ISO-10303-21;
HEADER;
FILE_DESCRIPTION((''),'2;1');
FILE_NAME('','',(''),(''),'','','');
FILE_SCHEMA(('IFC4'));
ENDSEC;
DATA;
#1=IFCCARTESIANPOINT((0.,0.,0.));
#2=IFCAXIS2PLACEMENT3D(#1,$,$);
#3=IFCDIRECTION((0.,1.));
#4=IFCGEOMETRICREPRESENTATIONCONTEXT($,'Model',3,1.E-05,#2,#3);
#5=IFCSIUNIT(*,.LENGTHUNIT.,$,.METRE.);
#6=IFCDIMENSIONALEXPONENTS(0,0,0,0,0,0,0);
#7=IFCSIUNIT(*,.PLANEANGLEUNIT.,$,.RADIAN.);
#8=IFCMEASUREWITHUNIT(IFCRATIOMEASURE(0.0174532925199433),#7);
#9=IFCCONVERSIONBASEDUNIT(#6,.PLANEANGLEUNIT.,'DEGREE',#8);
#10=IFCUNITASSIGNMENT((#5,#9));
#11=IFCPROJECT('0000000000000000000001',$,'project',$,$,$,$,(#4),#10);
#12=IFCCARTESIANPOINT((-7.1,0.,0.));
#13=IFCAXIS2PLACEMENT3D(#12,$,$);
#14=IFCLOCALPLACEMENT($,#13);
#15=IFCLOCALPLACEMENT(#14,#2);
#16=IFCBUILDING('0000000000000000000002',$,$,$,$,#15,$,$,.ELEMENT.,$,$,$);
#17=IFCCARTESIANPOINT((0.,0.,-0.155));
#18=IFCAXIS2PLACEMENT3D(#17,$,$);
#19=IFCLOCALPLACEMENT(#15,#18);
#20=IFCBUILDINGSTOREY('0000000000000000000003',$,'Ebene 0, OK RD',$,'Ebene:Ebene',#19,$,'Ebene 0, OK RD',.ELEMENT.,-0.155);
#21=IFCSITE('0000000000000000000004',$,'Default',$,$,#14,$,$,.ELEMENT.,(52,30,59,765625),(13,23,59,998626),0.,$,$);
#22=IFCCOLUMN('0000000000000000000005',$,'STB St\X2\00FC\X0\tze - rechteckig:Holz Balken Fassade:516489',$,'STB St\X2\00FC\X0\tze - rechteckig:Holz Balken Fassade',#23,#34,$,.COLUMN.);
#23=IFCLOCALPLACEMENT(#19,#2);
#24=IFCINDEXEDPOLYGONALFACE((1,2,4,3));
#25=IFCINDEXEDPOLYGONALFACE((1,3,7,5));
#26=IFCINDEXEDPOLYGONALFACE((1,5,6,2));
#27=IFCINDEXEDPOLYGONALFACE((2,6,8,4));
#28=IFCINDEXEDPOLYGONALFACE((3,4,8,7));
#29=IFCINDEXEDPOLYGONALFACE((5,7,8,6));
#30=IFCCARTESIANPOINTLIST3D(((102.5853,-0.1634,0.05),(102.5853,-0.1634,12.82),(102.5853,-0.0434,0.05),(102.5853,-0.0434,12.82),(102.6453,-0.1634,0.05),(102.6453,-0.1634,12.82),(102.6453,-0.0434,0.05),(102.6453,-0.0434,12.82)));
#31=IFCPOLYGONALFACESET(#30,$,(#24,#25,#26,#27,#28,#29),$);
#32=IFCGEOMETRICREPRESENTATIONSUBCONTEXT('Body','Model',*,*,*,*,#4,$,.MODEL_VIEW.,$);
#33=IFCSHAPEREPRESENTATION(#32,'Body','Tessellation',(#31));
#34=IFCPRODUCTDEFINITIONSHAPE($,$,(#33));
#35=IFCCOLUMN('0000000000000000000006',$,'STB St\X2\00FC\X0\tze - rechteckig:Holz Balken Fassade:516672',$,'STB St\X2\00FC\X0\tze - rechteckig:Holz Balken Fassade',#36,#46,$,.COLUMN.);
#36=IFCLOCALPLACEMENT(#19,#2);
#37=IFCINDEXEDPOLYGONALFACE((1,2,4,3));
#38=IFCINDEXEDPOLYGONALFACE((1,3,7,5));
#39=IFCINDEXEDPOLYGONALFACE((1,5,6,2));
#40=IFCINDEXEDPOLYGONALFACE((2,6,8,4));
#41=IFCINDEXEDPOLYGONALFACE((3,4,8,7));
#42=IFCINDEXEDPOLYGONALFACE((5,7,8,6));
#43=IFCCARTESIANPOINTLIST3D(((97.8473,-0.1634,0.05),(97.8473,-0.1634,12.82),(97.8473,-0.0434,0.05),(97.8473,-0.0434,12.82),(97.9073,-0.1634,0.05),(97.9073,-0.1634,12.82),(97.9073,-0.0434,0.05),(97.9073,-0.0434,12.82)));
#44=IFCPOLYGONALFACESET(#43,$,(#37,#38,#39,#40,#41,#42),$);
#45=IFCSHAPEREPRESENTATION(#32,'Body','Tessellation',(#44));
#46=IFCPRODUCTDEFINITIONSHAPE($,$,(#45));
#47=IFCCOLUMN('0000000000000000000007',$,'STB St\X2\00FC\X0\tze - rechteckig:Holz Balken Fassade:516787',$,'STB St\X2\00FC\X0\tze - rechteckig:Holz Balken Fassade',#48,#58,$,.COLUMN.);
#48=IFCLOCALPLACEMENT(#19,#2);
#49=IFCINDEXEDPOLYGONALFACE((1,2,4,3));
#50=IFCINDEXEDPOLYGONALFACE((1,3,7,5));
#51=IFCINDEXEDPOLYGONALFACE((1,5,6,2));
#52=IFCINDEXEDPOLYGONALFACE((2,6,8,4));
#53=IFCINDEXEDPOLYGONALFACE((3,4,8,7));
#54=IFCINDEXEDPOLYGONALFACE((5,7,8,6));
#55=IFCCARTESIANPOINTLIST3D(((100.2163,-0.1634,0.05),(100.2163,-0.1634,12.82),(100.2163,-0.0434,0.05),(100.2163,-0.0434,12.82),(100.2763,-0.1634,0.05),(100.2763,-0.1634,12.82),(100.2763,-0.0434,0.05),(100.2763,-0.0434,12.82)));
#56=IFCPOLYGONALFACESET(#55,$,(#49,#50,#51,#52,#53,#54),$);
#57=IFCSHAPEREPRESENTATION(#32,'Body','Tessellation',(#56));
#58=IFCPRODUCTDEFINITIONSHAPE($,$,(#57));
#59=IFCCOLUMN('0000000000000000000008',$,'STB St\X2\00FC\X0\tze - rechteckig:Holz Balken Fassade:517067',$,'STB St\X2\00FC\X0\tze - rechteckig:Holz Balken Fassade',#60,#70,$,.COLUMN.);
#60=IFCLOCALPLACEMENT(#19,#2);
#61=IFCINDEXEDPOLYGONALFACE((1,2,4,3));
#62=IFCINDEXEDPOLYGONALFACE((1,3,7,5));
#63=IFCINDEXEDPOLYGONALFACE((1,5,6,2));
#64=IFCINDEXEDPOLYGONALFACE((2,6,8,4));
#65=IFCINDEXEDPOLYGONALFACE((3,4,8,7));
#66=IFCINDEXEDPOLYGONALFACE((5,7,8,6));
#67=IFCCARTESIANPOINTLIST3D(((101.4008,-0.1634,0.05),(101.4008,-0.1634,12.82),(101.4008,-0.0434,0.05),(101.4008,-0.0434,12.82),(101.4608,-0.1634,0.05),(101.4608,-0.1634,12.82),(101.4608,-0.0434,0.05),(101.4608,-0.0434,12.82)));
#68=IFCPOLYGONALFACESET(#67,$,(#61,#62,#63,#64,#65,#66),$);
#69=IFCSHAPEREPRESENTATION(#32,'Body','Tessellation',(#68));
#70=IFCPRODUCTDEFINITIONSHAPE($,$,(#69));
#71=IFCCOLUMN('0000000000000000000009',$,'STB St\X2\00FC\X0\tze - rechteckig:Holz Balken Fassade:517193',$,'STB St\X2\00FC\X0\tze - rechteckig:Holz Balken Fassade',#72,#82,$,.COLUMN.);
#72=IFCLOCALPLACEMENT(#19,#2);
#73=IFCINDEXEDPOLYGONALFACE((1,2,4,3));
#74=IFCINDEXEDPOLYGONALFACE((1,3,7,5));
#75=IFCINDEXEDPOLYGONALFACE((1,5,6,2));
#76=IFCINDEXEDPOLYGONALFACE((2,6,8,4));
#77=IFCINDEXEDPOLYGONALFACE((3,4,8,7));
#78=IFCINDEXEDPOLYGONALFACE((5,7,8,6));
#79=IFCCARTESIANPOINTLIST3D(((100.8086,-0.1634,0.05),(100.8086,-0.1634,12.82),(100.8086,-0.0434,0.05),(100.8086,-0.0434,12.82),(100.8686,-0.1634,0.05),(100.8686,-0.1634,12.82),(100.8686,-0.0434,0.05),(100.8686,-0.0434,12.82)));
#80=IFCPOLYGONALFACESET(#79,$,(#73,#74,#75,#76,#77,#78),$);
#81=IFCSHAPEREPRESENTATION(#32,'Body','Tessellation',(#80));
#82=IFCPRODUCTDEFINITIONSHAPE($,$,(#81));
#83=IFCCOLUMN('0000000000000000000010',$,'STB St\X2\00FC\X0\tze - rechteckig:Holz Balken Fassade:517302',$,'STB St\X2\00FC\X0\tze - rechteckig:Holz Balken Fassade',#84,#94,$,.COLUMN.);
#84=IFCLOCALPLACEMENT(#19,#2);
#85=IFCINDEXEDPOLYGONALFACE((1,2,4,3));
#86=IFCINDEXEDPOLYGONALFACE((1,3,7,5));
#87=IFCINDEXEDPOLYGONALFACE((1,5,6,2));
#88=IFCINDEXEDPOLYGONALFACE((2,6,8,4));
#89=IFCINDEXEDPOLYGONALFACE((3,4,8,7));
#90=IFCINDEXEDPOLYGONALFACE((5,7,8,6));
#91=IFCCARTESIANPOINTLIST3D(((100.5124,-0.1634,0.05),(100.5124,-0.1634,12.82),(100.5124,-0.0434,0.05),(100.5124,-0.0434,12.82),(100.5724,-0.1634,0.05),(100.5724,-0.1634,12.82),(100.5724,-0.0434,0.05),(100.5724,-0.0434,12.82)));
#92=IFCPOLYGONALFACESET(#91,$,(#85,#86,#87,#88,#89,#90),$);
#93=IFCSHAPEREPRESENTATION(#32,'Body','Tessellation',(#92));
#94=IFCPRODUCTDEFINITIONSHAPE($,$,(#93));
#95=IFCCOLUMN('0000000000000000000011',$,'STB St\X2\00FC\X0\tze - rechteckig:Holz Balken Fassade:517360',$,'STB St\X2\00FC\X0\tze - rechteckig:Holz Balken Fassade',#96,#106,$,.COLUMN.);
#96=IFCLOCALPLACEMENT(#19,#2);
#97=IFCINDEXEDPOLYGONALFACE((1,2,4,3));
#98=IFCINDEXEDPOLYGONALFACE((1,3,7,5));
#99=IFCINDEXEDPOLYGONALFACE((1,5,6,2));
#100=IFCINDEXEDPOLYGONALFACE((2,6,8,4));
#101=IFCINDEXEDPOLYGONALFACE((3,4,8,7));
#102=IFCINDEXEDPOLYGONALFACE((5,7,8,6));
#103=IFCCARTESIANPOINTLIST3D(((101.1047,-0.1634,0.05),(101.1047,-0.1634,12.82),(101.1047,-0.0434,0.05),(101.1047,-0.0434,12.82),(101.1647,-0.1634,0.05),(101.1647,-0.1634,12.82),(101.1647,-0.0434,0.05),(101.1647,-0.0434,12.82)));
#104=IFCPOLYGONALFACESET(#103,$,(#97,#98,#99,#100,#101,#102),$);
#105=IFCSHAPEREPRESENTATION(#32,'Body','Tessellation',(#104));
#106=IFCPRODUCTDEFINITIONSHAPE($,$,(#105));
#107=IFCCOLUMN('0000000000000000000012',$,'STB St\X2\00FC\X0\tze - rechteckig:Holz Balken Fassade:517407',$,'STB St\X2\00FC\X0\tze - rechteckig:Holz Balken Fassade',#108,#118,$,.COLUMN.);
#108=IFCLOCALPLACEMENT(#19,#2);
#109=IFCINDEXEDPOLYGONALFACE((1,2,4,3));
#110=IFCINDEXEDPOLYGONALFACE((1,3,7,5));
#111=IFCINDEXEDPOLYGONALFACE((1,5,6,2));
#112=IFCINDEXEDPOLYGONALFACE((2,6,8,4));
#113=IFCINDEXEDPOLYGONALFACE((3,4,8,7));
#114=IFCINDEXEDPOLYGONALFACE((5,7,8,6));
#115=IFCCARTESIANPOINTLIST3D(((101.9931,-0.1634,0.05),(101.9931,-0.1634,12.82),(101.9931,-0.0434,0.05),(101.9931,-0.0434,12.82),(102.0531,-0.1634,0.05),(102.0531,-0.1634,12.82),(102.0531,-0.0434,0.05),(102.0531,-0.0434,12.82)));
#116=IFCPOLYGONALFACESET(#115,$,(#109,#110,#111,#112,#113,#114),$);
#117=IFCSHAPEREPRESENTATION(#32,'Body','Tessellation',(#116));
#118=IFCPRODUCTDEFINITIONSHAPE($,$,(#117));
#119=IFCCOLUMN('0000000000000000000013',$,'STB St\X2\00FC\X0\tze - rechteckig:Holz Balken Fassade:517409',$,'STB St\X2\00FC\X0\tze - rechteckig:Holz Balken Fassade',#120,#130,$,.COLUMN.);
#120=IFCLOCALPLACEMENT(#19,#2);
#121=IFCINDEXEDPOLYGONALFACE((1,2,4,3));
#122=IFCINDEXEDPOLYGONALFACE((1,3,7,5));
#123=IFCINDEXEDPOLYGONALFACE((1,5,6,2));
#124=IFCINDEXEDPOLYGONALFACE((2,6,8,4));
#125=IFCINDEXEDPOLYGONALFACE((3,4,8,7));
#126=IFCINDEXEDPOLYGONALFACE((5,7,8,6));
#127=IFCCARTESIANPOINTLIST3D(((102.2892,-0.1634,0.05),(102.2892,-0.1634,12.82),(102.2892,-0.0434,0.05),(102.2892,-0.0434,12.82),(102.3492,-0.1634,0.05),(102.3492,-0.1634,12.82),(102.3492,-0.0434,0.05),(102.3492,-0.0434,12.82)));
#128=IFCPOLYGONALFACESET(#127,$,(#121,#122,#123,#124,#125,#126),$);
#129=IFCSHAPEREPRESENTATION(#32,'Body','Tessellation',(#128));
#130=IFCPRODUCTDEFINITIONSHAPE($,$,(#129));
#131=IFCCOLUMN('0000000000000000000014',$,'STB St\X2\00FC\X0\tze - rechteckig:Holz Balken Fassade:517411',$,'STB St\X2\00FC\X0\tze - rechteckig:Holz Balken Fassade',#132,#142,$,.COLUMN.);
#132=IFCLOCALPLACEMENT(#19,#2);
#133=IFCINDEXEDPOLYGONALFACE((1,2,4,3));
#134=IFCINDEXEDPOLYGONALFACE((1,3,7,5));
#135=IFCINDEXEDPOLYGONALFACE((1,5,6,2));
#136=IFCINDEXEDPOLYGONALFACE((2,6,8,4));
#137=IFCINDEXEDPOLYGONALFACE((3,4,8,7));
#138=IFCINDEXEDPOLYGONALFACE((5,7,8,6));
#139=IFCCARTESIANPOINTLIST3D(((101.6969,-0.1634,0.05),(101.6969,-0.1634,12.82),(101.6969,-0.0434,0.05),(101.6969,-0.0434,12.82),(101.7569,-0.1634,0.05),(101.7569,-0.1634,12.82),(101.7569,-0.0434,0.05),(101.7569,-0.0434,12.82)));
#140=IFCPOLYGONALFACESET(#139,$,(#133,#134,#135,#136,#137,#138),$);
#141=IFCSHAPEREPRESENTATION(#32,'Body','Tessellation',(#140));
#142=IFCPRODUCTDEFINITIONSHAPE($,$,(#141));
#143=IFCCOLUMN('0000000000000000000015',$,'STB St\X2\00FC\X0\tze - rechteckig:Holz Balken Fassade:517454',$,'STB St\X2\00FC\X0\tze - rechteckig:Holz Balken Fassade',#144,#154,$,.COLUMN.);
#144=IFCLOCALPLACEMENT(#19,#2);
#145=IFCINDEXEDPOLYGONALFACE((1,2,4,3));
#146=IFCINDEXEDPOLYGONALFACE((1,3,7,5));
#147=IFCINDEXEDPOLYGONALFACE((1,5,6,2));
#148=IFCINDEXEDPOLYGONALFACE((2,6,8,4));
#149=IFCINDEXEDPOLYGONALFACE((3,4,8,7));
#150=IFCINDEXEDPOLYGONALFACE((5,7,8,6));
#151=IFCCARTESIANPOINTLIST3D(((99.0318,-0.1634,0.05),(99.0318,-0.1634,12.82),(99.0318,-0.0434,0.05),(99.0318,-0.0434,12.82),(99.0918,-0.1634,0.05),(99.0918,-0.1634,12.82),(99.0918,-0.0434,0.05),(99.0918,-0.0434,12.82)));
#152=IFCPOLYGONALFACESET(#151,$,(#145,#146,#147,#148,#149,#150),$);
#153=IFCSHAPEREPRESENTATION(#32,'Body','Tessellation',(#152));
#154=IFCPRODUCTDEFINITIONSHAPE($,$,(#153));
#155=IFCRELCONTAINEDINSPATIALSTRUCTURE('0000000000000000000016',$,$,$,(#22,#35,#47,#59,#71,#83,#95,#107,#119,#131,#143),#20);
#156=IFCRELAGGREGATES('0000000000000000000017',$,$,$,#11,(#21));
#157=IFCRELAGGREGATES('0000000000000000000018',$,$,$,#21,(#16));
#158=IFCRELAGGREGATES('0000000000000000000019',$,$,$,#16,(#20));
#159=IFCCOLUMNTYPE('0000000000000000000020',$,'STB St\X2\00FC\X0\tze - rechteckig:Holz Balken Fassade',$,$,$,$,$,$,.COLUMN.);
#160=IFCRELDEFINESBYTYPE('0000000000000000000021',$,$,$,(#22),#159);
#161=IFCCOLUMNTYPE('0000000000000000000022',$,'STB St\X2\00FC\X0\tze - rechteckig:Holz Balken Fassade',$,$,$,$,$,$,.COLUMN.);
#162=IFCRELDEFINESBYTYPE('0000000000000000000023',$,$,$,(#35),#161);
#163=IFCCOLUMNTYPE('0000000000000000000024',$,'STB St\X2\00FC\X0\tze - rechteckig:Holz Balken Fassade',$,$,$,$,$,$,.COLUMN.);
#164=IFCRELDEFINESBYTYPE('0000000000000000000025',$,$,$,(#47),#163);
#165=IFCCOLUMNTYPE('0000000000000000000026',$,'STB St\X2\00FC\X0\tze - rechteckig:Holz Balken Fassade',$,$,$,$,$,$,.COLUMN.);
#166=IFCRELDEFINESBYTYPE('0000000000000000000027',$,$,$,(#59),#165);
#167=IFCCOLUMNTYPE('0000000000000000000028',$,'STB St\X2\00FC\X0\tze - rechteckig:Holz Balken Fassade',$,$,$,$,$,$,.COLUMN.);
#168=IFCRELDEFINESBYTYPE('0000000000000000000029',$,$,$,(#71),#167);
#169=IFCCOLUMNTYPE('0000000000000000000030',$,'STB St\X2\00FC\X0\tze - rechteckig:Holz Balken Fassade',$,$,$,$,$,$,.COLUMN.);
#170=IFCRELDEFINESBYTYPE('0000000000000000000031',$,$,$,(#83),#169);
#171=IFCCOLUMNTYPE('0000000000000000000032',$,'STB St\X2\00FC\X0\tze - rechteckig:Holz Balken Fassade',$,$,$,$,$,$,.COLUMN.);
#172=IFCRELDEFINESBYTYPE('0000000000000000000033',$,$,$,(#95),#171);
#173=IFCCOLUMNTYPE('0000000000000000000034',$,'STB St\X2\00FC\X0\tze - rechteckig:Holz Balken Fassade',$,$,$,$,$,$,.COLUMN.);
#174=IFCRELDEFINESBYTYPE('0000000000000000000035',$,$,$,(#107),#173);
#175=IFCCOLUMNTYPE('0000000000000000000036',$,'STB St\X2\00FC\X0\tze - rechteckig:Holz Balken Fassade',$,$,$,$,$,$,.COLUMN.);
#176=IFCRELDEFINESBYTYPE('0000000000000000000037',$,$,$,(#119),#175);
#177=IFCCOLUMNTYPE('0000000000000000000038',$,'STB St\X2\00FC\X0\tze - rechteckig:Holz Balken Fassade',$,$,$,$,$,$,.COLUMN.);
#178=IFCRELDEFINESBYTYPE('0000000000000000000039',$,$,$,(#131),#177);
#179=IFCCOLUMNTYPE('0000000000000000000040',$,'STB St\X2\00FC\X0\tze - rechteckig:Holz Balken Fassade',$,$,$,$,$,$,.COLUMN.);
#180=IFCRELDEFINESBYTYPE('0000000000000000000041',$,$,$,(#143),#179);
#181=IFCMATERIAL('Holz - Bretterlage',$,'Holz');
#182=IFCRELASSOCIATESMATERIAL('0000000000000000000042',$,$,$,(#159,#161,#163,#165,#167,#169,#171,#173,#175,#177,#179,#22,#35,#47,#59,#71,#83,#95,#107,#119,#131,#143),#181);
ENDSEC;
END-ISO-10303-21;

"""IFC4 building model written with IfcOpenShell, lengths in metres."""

from ifc_helpers import new_model, entity, si_unit, converted_unit, direction, frame, frame_2d, origin, place, context, subcontext, project, spatial, rectangle, extrude, source, transform, mapped, material, material_profile, profile_set, profile_usage, type_object, type_shapes, element, save


model = new_model("IFC4")

# Units and contexts
model_context = context("Model", 3, precision=1e-05, world=origin(), true_north=direction((0.0, 1.0)))
body_context = subcontext(model_context, "Body", "Model", "MODEL_VIEW")
ifc_project = project(units=[si_unit("LENGTHUNIT", "METRE"), converted_unit("PLANEANGLEUNIT", "DEGREE", entity("IfcRatioMeasure", 0.0174532925199433), si_unit("PLANEANGLEUNIT", "RADIAN"), dimensions=[0, 0, 0, 0, 0, 0, 0])], contexts=[model_context])

# Site, building, storey
site_placement = place(None, frame((-7.1, 0.0, 0.0)))
site = spatial("IfcSite", under=ifc_project, at=site_placement, Name="Default", CompositionType="ELEMENT", RefLatitude=(52, 30, 59, 765625), RefLongitude=(13, 23, 59, 998626), RefElevation=0.0)
building_placement = place(site_placement, origin())
building = spatial("IfcBuilding", under=site, at=building_placement, CompositionType="ELEMENT")
storey_placement = place(building_placement, frame((0.0, 0.0, -0.155)))
storey = spatial("IfcBuildingStorey", under=building, at=storey_placement, Name="Ebene 0, OK RD", ObjectType="Ebene:Ebene", LongName="Ebene 0, OK RD", CompositionType="ELEMENT", Elevation=-0.155)

# Columns
ifc_material_1 = material(Name="Holz - Bretterlage", Category="Holz")
ifc_material_profile = material_profile(ifc_material_1, rectangle(XDim=0.12, YDim=0.06, at=frame_2d((0.0, 0.0), x_axis=(1.0, 0.0))), Name="Holz Balken Fassade")
ifc_profile_set = profile_set([ifc_material_profile], Name="Holz Balken Fassade")
ifc_profile_usage_1 = profile_usage(ifc_profile_set)
column_type_1 = type_object("IfcColumnType", Name="STB Stütze - rechteckig:Holz Balken Fassade", PredefinedType="COLUMN", material=ifc_profile_set)
shared_shape_1 = source(origin(), body_context, "Body", "SweptSolid", [
    extrude(rectangle(XDim=0.12, YDim=0.06, at=frame_2d((0.0, 0.0), x_axis=(1.0, 0.0))), frame((102.6153, -0.1034, -0.105), z_axis=(0.0, 0.0, 1.0), x_axis=(0.0, -1.0, 0.0)), (0.0, 0.0, 1.0), 12.77),
])
type_shapes(column_type_1, [shared_shape_1])
column_1_placement = place(storey_placement, frame((0.0, 0.0, 0.155)))
element("IfcColumn", 1, at=column_1_placement, inside=storey, type_object=column_type_1, material=ifc_profile_usage_1, Name="STB Stütze - rechteckig:Holz Balken Fassade:516489", ObjectType="STB Stütze - rechteckig:Holz Balken Fassade", PredefinedType="COLUMN", context=body_context, shape_type="MappedRepresentation", body=[
    mapped(shared_shape_1, transform((0.0, 0.0, 0.0), scale=1.0)),
])
ifc_profile_usage_2 = profile_usage(ifc_profile_set)
column_type_2 = type_object("IfcColumnType", Name="STB Stütze - rechteckig:Holz Balken Fassade", PredefinedType="COLUMN", material=ifc_profile_set)
shared_shape_2 = source(origin(), body_context, "Body", "SweptSolid", [
    extrude(rectangle(XDim=0.12, YDim=0.06, at=frame_2d((0.0, 0.0), x_axis=(1.0, 0.0))), frame((97.8773, -0.1034, -0.105), z_axis=(0.0, 0.0, 1.0), x_axis=(0.0, -1.0, 0.0)), (0.0, 0.0, 1.0), 12.77),
])
type_shapes(column_type_2, [shared_shape_2])
column_2_placement = place(storey_placement, frame((0.0, 0.0, 0.155)))
element("IfcColumn", 2, at=column_2_placement, inside=storey, type_object=column_type_2, material=ifc_profile_usage_2, Name="STB Stütze - rechteckig:Holz Balken Fassade:516672", ObjectType="STB Stütze - rechteckig:Holz Balken Fassade", PredefinedType="COLUMN", context=body_context, shape_type="MappedRepresentation", body=[
    mapped(shared_shape_2, transform((0.0, 0.0, 0.0), scale=1.0)),
])
ifc_profile_usage_3 = profile_usage(ifc_profile_set)
column_type_3 = type_object("IfcColumnType", Name="STB Stütze - rechteckig:Holz Balken Fassade", PredefinedType="COLUMN", material=ifc_profile_set)
shared_shape_3 = source(origin(), body_context, "Body", "SweptSolid", [
    extrude(rectangle(XDim=0.12, YDim=0.06, at=frame_2d((0.0, 0.0), x_axis=(1.0, 0.0))), frame((100.2463, -0.1034, -0.105), z_axis=(0.0, 0.0, 1.0), x_axis=(0.0, -1.0, 0.0)), (0.0, 0.0, 1.0), 12.77),
])
type_shapes(column_type_3, [shared_shape_3])
column_3_placement = place(storey_placement, frame((0.0, 0.0, 0.155)))
element("IfcColumn", 3, at=column_3_placement, inside=storey, type_object=column_type_3, material=ifc_profile_usage_3, Name="STB Stütze - rechteckig:Holz Balken Fassade:516787", ObjectType="STB Stütze - rechteckig:Holz Balken Fassade", PredefinedType="COLUMN", context=body_context, shape_type="MappedRepresentation", body=[
    mapped(shared_shape_3, transform((0.0, 0.0, 0.0), scale=1.0)),
])
ifc_profile_usage_4 = profile_usage(ifc_profile_set)
column_type_4 = type_object("IfcColumnType", Name="STB Stütze - rechteckig:Holz Balken Fassade", PredefinedType="COLUMN", material=ifc_profile_set)
shared_shape_4 = source(origin(), body_context, "Body", "SweptSolid", [
    extrude(rectangle(XDim=0.12, YDim=0.06, at=frame_2d((0.0, 0.0), x_axis=(1.0, 0.0))), frame((101.4308, -0.1034, -0.105), z_axis=(0.0, 0.0, 1.0), x_axis=(0.0, -1.0, 0.0)), (0.0, 0.0, 1.0), 12.77),
])
type_shapes(column_type_4, [shared_shape_4])
column_4_placement = place(storey_placement, frame((0.0, 0.0, 0.155)))
element("IfcColumn", 4, at=column_4_placement, inside=storey, type_object=column_type_4, material=ifc_profile_usage_4, Name="STB Stütze - rechteckig:Holz Balken Fassade:517067", ObjectType="STB Stütze - rechteckig:Holz Balken Fassade", PredefinedType="COLUMN", context=body_context, shape_type="MappedRepresentation", body=[
    mapped(shared_shape_4, transform((0.0, 0.0, 0.0), scale=1.0)),
])
ifc_profile_usage_5 = profile_usage(ifc_profile_set)
column_type_5 = type_object("IfcColumnType", Name="STB Stütze - rechteckig:Holz Balken Fassade", PredefinedType="COLUMN", material=ifc_profile_set)
shared_shape_5 = source(origin(), body_context, "Body", "SweptSolid", [
    extrude(rectangle(XDim=0.12, YDim=0.06, at=frame_2d((0.0, 0.0), x_axis=(1.0, 0.0))), frame((100.8386, -0.1034, -0.105), z_axis=(0.0, 0.0, 1.0), x_axis=(0.0, -1.0, 0.0)), (0.0, 0.0, 1.0), 12.77),
])
type_shapes(column_type_5, [shared_shape_5])
column_5_placement = place(storey_placement, frame((0.0, 0.0, 0.155)))
element("IfcColumn", 5, at=column_5_placement, inside=storey, type_object=column_type_5, material=ifc_profile_usage_5, Name="STB Stütze - rechteckig:Holz Balken Fassade:517193", ObjectType="STB Stütze - rechteckig:Holz Balken Fassade", PredefinedType="COLUMN", context=body_context, shape_type="MappedRepresentation", body=[
    mapped(shared_shape_5, transform((0.0, 0.0, 0.0), scale=1.0)),
])
ifc_profile_usage_6 = profile_usage(ifc_profile_set)
column_type_6 = type_object("IfcColumnType", Name="STB Stütze - rechteckig:Holz Balken Fassade", PredefinedType="COLUMN", material=ifc_profile_set)
shared_shape_6 = source(origin(), body_context, "Body", "SweptSolid", [
    extrude(rectangle(XDim=0.12, YDim=0.06, at=frame_2d((0.0, 0.0), x_axis=(1.0, 0.0))), frame((100.5424, -0.1034, -0.105), z_axis=(0.0, 0.0, 1.0), x_axis=(0.0, -1.0, 0.0)), (0.0, 0.0, 1.0), 12.77),
])
type_shapes(column_type_6, [shared_shape_6])
column_6_placement = place(storey_placement, frame((0.0, 0.0, 0.155)))
element("IfcColumn", 6, at=column_6_placement, inside=storey, type_object=column_type_6, material=ifc_profile_usage_6, Name="STB Stütze - rechteckig:Holz Balken Fassade:517302", ObjectType="STB Stütze - rechteckig:Holz Balken Fassade", PredefinedType="COLUMN", context=body_context, shape_type="MappedRepresentation", body=[
    mapped(shared_shape_6, transform((0.0, 0.0, 0.0), scale=1.0)),
])
ifc_profile_usage_7 = profile_usage(ifc_profile_set)
column_type_7 = type_object("IfcColumnType", Name="STB Stütze - rechteckig:Holz Balken Fassade", PredefinedType="COLUMN", material=ifc_profile_set)
shared_shape_7 = source(origin(), body_context, "Body", "SweptSolid", [
    extrude(rectangle(XDim=0.12, YDim=0.06, at=frame_2d((0.0, 0.0), x_axis=(1.0, 0.0))), frame((101.1347, -0.1034, -0.105), z_axis=(0.0, 0.0, 1.0), x_axis=(0.0, -1.0, 0.0)), (0.0, 0.0, 1.0), 12.77),
])
type_shapes(column_type_7, [shared_shape_7])
column_7_placement = place(storey_placement, frame((0.0, 0.0, 0.155)))
element("IfcColumn", 7, at=column_7_placement, inside=storey, type_object=column_type_7, material=ifc_profile_usage_7, Name="STB Stütze - rechteckig:Holz Balken Fassade:517360", ObjectType="STB Stütze - rechteckig:Holz Balken Fassade", PredefinedType="COLUMN", context=body_context, shape_type="MappedRepresentation", body=[
    mapped(shared_shape_7, transform((0.0, 0.0, 0.0), scale=1.0)),
])
ifc_profile_usage_8 = profile_usage(ifc_profile_set)
column_type_8 = type_object("IfcColumnType", Name="STB Stütze - rechteckig:Holz Balken Fassade", PredefinedType="COLUMN", material=ifc_profile_set)
shared_shape_8 = source(origin(), body_context, "Body", "SweptSolid", [
    extrude(rectangle(XDim=0.12, YDim=0.06, at=frame_2d((0.0, 0.0), x_axis=(1.0, 0.0))), frame((102.0231, -0.1034, -0.105), z_axis=(0.0, 0.0, 1.0), x_axis=(0.0, -1.0, 0.0)), (0.0, 0.0, 1.0), 12.77),
])
type_shapes(column_type_8, [shared_shape_8])
column_8_placement = place(storey_placement, frame((0.0, 0.0, 0.155)))
element("IfcColumn", 8, at=column_8_placement, inside=storey, type_object=column_type_8, material=ifc_profile_usage_8, Name="STB Stütze - rechteckig:Holz Balken Fassade:517407", ObjectType="STB Stütze - rechteckig:Holz Balken Fassade", PredefinedType="COLUMN", context=body_context, shape_type="MappedRepresentation", body=[
    mapped(shared_shape_8, transform((0.0, 0.0, 0.0), scale=1.0)),
])
ifc_profile_usage_9 = profile_usage(ifc_profile_set)
column_type_9 = type_object("IfcColumnType", Name="STB Stütze - rechteckig:Holz Balken Fassade", PredefinedType="COLUMN", material=ifc_profile_set)
shared_shape_9 = source(origin(), body_context, "Body", "SweptSolid", [
    extrude(rectangle(XDim=0.12, YDim=0.06, at=frame_2d((0.0, 0.0), x_axis=(1.0, 0.0))), frame((102.3192, -0.1034, -0.105), z_axis=(0.0, 0.0, 1.0), x_axis=(0.0, -1.0, 0.0)), (0.0, 0.0, 1.0), 12.77),
])
type_shapes(column_type_9, [shared_shape_9])
column_9_placement = place(storey_placement, frame((0.0, 0.0, 0.155)))
element("IfcColumn", 9, at=column_9_placement, inside=storey, type_object=column_type_9, material=ifc_profile_usage_9, Name="STB Stütze - rechteckig:Holz Balken Fassade:517409", ObjectType="STB Stütze - rechteckig:Holz Balken Fassade", PredefinedType="COLUMN", context=body_context, shape_type="MappedRepresentation", body=[
    mapped(shared_shape_9, transform((0.0, 0.0, 0.0), scale=1.0)),
])
ifc_profile_usage_10 = profile_usage(ifc_profile_set)
column_type_10 = type_object("IfcColumnType", Name="STB Stütze - rechteckig:Holz Balken Fassade", PredefinedType="COLUMN", material=ifc_profile_set)
shared_shape_10 = source(origin(), body_context, "Body", "SweptSolid", [
    extrude(rectangle(XDim=0.12, YDim=0.06, at=frame_2d((0.0, 0.0), x_axis=(1.0, 0.0))), frame((101.7269, -0.1034, -0.105), z_axis=(0.0, 0.0, 1.0), x_axis=(0.0, -1.0, 0.0)), (0.0, 0.0, 1.0), 12.77),
])
type_shapes(column_type_10, [shared_shape_10])
column_10_placement = place(storey_placement, frame((0.0, 0.0, 0.155)))
element("IfcColumn", 10, at=column_10_placement, inside=storey, type_object=column_type_10, material=ifc_profile_usage_10, Name="STB Stütze - rechteckig:Holz Balken Fassade:517411", ObjectType="STB Stütze - rechteckig:Holz Balken Fassade", PredefinedType="COLUMN", context=body_context, shape_type="MappedRepresentation", body=[
    mapped(shared_shape_10, transform((0.0, 0.0, 0.0), scale=1.0)),
])
ifc_profile_usage_11 = profile_usage(ifc_profile_set)
column_type_11 = type_object("IfcColumnType", Name="STB Stütze - rechteckig:Holz Balken Fassade", PredefinedType="COLUMN", material=ifc_profile_set)
shared_shape_11 = source(origin(), body_context, "Body", "SweptSolid", [
    extrude(rectangle(XDim=0.12, YDim=0.06, at=frame_2d((0.0, 0.0), x_axis=(1.0, 0.0))), frame((99.0618, -0.1034, -0.105), z_axis=(0.0, 0.0, 1.0), x_axis=(0.0, -1.0, 0.0)), (0.0, 0.0, 1.0), 12.77),
])
type_shapes(column_type_11, [shared_shape_11])
column_11_placement = place(storey_placement, frame((0.0, 0.0, 0.155)))
element("IfcColumn", 11, at=column_11_placement, inside=storey, type_object=column_type_11, material=ifc_profile_usage_11, Name="STB Stütze - rechteckig:Holz Balken Fassade:517454", ObjectType="STB Stütze - rechteckig:Holz Balken Fassade", PredefinedType="COLUMN", context=body_context, shape_type="MappedRepresentation", body=[
    mapped(shared_shape_11, transform((0.0, 0.0, 0.0), scale=1.0)),
])

save(model, "model.ifc")
